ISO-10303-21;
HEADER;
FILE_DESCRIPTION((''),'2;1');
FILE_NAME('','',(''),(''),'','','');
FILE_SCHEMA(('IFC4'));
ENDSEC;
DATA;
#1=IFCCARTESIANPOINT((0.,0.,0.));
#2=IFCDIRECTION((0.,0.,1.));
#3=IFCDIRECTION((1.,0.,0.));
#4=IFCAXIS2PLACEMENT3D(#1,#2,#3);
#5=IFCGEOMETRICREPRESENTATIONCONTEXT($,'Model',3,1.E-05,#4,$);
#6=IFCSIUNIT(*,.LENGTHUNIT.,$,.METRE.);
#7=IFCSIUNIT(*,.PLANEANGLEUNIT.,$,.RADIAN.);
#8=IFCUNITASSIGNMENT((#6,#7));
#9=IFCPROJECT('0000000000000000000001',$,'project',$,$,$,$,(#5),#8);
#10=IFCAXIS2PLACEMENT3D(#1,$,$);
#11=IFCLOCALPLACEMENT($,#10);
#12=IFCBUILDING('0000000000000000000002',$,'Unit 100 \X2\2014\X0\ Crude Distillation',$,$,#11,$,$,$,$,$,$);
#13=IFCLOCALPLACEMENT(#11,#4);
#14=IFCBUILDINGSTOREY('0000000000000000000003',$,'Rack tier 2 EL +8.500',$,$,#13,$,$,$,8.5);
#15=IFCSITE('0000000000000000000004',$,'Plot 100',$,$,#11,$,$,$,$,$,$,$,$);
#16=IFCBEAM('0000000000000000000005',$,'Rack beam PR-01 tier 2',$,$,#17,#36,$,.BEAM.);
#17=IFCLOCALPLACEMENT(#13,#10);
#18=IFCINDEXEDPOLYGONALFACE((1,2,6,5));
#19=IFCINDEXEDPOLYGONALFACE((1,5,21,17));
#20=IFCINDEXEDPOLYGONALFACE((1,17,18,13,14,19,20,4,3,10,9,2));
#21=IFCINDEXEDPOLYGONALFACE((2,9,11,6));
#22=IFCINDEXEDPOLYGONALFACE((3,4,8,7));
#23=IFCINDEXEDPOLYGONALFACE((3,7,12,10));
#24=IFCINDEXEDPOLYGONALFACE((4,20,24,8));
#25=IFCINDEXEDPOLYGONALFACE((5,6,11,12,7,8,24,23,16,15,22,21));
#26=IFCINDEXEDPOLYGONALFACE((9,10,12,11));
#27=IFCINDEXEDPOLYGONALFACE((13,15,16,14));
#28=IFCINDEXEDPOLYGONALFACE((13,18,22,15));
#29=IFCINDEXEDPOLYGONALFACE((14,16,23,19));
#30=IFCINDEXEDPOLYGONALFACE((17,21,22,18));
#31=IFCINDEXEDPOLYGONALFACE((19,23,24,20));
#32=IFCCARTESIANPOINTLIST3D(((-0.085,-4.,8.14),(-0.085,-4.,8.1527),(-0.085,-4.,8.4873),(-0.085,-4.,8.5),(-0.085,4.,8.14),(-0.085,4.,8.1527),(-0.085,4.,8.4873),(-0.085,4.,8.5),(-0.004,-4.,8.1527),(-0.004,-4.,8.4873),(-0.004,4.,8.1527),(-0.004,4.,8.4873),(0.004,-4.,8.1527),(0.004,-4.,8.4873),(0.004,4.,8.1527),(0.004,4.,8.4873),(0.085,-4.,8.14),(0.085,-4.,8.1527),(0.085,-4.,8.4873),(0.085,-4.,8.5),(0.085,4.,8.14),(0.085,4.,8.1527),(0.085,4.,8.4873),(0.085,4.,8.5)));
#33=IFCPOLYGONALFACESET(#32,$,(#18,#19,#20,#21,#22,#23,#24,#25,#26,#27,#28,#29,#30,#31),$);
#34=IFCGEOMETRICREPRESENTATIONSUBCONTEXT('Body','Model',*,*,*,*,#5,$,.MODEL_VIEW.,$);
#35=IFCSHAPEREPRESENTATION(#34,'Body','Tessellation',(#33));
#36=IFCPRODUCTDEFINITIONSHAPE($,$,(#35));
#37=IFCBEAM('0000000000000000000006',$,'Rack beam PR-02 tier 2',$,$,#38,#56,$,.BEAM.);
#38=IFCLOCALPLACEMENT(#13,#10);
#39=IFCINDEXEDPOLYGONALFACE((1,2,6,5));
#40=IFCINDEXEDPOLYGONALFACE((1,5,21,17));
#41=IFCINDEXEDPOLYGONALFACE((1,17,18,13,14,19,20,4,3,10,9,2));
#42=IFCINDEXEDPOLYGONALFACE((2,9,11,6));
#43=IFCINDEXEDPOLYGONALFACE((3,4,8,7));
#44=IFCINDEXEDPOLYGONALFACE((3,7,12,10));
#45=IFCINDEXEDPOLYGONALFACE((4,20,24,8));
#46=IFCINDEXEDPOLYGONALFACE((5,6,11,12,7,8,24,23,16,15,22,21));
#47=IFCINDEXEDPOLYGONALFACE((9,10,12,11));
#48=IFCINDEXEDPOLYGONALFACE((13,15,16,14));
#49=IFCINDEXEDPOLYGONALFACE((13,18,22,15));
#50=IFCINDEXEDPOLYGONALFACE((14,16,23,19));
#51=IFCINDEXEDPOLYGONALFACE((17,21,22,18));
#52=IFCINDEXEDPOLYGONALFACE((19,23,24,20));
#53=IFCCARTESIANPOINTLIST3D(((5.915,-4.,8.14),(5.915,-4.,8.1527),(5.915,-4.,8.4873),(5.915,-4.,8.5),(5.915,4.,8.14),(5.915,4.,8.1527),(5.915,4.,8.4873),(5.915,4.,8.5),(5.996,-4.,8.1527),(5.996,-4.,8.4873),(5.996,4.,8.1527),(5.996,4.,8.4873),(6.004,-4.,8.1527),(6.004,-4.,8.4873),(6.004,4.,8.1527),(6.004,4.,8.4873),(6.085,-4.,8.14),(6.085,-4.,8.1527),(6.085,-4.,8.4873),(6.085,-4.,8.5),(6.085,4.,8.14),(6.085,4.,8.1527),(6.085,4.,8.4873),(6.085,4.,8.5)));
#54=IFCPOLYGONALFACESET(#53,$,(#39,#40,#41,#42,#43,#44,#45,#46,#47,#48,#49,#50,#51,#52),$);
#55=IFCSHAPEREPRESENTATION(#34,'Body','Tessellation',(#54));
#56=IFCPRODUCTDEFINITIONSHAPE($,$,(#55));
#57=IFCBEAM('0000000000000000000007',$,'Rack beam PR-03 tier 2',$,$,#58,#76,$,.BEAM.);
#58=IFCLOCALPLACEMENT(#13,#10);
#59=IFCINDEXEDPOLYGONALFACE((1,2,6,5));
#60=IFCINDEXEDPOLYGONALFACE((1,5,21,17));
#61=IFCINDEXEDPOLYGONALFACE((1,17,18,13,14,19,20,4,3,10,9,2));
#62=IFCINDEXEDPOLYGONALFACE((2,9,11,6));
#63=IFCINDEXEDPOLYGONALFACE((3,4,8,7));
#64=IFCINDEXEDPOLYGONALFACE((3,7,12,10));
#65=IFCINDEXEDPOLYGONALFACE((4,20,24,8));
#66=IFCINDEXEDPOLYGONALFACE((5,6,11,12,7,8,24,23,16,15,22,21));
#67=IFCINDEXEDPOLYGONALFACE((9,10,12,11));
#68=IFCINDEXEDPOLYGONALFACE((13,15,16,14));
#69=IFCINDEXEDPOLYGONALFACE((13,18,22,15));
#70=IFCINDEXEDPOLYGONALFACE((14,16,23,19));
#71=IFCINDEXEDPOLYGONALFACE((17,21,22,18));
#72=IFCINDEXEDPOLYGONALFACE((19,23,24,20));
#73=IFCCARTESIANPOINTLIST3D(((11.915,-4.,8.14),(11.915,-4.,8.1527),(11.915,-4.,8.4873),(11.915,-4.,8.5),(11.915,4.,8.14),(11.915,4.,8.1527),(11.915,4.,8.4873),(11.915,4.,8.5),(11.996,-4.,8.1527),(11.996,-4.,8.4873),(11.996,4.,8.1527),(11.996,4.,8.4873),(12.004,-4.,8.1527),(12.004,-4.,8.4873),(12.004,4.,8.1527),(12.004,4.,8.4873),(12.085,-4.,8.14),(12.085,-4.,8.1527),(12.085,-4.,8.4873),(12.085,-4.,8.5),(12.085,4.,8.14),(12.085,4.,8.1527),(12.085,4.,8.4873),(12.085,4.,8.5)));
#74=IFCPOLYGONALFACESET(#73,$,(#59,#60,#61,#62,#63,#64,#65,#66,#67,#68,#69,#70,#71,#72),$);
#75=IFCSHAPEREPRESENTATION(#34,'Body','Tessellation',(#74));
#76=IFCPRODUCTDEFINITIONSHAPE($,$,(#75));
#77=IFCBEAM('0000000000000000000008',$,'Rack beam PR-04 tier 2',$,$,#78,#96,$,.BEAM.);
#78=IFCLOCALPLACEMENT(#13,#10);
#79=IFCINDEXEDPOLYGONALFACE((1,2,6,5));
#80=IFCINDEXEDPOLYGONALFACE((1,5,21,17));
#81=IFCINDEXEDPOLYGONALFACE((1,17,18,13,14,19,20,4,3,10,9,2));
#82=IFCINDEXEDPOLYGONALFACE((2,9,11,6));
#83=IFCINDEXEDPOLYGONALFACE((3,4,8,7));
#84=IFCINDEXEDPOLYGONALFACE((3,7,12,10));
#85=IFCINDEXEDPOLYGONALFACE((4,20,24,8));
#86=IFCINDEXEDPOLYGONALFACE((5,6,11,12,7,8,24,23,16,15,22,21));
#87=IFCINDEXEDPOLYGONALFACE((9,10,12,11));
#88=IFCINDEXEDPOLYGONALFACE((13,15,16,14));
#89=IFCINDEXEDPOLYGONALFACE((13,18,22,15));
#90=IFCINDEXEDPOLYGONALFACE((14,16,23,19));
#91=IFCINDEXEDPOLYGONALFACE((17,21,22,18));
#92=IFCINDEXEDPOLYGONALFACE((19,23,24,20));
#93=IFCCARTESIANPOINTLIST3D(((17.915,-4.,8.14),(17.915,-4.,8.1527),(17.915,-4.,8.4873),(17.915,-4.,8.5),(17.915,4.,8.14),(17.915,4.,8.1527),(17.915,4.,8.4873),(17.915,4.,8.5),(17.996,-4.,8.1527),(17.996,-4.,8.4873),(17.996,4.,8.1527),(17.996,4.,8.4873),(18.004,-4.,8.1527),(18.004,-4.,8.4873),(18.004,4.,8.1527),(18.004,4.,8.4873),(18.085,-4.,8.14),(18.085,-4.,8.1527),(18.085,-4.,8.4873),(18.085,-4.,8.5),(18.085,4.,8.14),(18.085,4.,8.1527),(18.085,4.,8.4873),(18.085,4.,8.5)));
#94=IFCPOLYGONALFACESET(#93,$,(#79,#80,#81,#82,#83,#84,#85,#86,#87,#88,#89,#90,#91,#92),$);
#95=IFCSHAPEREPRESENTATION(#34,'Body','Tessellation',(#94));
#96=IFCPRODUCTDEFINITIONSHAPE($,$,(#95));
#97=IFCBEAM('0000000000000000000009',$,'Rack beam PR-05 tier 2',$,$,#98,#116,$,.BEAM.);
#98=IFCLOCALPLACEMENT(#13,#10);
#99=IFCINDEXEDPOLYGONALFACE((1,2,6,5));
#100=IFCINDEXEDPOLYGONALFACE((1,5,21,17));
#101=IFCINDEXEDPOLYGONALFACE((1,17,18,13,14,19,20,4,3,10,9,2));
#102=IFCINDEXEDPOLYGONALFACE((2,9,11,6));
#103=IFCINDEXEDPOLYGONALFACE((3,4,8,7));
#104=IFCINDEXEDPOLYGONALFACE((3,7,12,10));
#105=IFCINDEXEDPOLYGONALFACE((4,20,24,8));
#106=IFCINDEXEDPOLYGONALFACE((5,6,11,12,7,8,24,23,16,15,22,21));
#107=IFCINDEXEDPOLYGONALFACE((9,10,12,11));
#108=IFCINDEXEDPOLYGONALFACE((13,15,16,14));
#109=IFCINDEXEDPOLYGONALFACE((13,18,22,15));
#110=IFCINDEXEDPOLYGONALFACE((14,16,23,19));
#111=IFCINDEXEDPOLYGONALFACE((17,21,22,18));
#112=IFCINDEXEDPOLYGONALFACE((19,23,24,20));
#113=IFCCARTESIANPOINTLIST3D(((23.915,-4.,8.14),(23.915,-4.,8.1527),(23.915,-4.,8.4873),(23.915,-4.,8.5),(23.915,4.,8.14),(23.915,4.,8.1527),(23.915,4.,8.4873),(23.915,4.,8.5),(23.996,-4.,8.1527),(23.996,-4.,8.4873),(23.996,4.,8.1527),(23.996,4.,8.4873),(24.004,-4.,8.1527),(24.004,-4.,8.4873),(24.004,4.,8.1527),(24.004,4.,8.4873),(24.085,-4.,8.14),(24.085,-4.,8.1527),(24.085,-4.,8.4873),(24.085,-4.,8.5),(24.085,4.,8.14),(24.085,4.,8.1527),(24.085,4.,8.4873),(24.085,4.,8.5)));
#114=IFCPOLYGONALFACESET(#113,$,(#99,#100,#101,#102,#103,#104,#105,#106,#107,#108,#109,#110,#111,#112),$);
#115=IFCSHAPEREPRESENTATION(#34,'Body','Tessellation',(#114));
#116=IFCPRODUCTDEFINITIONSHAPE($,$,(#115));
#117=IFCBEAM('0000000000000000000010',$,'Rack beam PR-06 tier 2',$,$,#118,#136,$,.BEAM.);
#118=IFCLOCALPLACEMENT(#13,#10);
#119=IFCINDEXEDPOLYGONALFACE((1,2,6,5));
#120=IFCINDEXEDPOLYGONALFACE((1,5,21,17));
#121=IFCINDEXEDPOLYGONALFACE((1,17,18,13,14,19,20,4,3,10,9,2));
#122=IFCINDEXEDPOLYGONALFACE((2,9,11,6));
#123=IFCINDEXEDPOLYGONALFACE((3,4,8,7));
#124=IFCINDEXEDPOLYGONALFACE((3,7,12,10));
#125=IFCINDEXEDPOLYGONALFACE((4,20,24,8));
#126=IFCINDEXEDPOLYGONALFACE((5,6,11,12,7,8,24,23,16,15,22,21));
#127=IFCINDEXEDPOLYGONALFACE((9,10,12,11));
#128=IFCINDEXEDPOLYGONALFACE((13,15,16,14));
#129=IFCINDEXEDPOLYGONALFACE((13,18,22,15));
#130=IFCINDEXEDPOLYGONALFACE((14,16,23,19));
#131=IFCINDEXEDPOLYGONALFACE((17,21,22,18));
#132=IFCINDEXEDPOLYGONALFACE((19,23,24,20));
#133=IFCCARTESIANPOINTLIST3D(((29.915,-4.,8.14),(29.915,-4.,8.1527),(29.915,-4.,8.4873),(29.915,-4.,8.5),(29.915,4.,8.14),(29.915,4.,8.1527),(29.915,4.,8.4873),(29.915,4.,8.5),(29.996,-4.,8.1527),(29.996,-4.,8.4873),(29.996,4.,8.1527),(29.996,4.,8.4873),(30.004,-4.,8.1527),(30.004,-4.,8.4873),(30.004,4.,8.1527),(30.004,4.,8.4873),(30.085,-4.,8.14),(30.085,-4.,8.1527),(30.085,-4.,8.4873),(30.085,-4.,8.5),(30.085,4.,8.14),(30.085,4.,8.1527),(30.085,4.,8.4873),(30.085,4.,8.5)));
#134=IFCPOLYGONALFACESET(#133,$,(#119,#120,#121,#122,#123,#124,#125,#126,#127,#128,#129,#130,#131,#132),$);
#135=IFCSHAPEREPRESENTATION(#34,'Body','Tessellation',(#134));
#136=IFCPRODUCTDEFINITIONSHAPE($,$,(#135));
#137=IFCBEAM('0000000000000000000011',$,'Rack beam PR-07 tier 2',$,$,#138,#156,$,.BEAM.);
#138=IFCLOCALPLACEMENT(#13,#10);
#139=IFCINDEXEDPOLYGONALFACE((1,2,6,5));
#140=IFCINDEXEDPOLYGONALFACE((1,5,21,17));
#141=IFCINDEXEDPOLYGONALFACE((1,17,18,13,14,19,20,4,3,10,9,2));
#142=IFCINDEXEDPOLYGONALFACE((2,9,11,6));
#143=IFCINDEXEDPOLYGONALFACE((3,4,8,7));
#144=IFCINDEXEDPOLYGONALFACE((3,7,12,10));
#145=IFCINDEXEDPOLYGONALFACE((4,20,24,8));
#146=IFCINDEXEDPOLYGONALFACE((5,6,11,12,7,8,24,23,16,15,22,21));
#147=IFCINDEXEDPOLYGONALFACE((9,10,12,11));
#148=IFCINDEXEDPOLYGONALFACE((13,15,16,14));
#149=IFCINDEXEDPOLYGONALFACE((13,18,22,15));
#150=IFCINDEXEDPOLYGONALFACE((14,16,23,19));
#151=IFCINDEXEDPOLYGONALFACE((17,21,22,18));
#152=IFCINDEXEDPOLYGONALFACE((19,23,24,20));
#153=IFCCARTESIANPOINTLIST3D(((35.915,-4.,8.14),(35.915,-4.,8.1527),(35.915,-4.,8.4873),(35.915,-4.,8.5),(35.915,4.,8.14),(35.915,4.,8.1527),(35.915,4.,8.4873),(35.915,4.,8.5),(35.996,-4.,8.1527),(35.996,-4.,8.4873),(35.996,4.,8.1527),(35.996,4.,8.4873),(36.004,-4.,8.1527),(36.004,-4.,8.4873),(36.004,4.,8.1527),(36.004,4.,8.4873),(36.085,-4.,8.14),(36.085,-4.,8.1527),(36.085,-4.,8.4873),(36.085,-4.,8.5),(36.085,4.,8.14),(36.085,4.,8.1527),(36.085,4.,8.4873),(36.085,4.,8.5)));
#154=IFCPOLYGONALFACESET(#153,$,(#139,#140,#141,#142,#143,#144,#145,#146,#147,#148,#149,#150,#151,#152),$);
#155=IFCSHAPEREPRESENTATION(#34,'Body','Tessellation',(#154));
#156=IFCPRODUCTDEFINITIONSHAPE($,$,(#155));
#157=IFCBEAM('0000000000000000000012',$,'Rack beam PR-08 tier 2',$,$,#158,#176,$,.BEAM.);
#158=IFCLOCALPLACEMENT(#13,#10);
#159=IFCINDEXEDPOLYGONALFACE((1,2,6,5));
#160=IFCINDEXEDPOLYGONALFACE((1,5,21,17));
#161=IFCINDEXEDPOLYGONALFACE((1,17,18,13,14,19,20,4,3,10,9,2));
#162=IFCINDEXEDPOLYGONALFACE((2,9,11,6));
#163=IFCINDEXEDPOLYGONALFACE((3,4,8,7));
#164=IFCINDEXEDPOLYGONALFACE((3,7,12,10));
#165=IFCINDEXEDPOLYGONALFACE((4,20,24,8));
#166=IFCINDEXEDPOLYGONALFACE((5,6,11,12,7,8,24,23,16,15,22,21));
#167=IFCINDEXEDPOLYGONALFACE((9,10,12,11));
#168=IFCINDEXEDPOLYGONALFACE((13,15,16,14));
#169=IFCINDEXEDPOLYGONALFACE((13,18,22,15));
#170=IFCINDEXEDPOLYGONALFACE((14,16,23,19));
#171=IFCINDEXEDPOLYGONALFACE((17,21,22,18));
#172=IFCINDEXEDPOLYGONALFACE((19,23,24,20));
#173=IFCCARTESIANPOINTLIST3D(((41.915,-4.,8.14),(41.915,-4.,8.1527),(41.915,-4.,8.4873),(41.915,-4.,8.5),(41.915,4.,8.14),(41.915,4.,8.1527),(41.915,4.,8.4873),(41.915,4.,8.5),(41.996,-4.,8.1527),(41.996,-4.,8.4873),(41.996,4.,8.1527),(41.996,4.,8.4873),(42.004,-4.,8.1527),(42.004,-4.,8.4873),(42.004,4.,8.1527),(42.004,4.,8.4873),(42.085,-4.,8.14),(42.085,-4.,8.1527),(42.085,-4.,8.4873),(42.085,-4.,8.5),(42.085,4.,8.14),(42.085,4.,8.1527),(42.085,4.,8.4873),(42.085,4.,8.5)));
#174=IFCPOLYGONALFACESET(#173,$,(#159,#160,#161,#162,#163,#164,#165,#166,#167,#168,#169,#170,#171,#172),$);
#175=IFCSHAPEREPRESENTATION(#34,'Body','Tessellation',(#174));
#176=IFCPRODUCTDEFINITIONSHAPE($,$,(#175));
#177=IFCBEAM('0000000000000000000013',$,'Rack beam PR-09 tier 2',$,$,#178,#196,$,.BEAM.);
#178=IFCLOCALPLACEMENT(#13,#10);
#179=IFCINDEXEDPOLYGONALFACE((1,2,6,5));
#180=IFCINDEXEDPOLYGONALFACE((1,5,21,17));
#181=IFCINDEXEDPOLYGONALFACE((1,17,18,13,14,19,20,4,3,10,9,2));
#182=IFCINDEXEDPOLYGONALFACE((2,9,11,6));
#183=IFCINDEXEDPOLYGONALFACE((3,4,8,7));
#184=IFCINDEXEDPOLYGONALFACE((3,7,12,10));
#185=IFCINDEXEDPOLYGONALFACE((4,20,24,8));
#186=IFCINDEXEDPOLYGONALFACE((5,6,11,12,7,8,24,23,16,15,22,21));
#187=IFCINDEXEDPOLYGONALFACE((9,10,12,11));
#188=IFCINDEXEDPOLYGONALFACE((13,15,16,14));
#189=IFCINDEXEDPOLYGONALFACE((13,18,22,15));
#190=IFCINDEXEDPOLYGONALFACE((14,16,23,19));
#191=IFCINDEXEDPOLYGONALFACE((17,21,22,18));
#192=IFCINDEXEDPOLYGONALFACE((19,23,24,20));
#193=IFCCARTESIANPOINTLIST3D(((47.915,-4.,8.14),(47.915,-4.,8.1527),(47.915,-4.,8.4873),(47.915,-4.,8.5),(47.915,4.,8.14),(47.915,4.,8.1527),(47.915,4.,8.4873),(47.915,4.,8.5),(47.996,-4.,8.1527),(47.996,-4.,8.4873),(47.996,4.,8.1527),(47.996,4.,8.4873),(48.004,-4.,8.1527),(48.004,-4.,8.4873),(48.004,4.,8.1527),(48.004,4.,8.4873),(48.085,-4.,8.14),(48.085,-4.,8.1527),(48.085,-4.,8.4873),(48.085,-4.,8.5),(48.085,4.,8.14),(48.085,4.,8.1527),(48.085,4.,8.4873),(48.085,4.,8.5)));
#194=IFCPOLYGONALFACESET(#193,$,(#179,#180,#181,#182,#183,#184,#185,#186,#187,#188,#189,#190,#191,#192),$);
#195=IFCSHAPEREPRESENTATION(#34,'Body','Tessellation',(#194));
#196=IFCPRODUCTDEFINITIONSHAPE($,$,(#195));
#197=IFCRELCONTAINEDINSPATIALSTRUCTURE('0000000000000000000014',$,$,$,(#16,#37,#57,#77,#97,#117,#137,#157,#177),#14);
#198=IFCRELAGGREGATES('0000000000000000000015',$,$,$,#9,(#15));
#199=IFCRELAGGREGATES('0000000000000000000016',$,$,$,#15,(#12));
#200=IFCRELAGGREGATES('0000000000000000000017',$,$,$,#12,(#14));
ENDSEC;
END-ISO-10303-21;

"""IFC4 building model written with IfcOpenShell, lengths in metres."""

from ifc_helpers import new_model, si_unit, frame, origin, origin_with_axes, origin_2d, place, context, subcontext, project, spatial, i_section, extrude, element, save


model = new_model("IFC4")

# Units and contexts
model_context = context("Model", 3, precision=1e-05, world=origin_with_axes())
body_context = subcontext(model_context, "Body", "Model", "MODEL_VIEW")
ifc_project = project(units=[si_unit("LENGTHUNIT", "METRE"), si_unit("PLANEANGLEUNIT", "RADIAN")], contexts=[model_context])

# Site, building, storey
placement = place(None, origin())
site = spatial("IfcSite", under=ifc_project, at=placement, Name="Plot 100")
building = spatial("IfcBuilding", under=site, at=placement, Name="Unit 100 — Crude Distillation")
storey_placement = place(placement, origin_with_axes())
storey = spatial("IfcBuildingStorey", under=building, at=storey_placement, Name="Rack tier 2 EL +8.500", Elevation=8.5)

# Beams
beam_1_placement = place(storey_placement, origin_with_axes())
element("IfcBeam", 1, at=beam_1_placement, inside=storey, Name="Rack beam PR-01 tier 2", PredefinedType="BEAM", context=body_context, shape_type="SweptSolid", body=[
    extrude(i_section(OverallWidth=0.17, OverallDepth=0.36, WebThickness=0.008, FlangeThickness=0.0127, at=origin_2d()), frame((0.0, -4.0, 8.32), z_axis=(0.0, 1.0, 0.0), x_axis=(-1.0, 0.0, 0.0)), (0.0, 0.0, 1.0), 8.0),
])
beam_2_placement = place(storey_placement, origin_with_axes())
element("IfcBeam", 2, at=beam_2_placement, inside=storey, Name="Rack beam PR-02 tier 2", PredefinedType="BEAM", context=body_context, shape_type="SweptSolid", body=[
    extrude(i_section(OverallWidth=0.17, OverallDepth=0.36, WebThickness=0.008, FlangeThickness=0.0127, at=origin_2d()), frame((6.0, -4.0, 8.32), z_axis=(0.0, 1.0, 0.0), x_axis=(-1.0, 0.0, 0.0)), (0.0, 0.0, 1.0), 8.0),
])
beam_3_placement = place(storey_placement, origin_with_axes())
element("IfcBeam", 3, at=beam_3_placement, inside=storey, Name="Rack beam PR-03 tier 2", PredefinedType="BEAM", context=body_context, shape_type="SweptSolid", body=[
    extrude(i_section(OverallWidth=0.17, OverallDepth=0.36, WebThickness=0.008, FlangeThickness=0.0127, at=origin_2d()), frame((12.0, -4.0, 8.32), z_axis=(0.0, 1.0, 0.0), x_axis=(-1.0, 0.0, 0.0)), (0.0, 0.0, 1.0), 8.0),
])
beam_4_placement = place(storey_placement, origin_with_axes())
element("IfcBeam", 4, at=beam_4_placement, inside=storey, Name="Rack beam PR-04 tier 2", PredefinedType="BEAM", context=body_context, shape_type="SweptSolid", body=[
    extrude(i_section(OverallWidth=0.17, OverallDepth=0.36, WebThickness=0.008, FlangeThickness=0.0127, at=origin_2d()), frame((18.0, -4.0, 8.32), z_axis=(0.0, 1.0, 0.0), x_axis=(-1.0, 0.0, 0.0)), (0.0, 0.0, 1.0), 8.0),
])
beam_5_placement = place(storey_placement, origin_with_axes())
element("IfcBeam", 5, at=beam_5_placement, inside=storey, Name="Rack beam PR-05 tier 2", PredefinedType="BEAM", context=body_context, shape_type="SweptSolid", body=[
    extrude(i_section(OverallWidth=0.17, OverallDepth=0.36, WebThickness=0.008, FlangeThickness=0.0127, at=origin_2d()), frame((24.0, -4.0, 8.32), z_axis=(0.0, 1.0, 0.0), x_axis=(-1.0, 0.0, 0.0)), (0.0, 0.0, 1.0), 8.0),
])
beam_6_placement = place(storey_placement, origin_with_axes())
element("IfcBeam", 6, at=beam_6_placement, inside=storey, Name="Rack beam PR-06 tier 2", PredefinedType="BEAM", context=body_context, shape_type="SweptSolid", body=[
    extrude(i_section(OverallWidth=0.17, OverallDepth=0.36, WebThickness=0.008, FlangeThickness=0.0127, at=origin_2d()), frame((30.0, -4.0, 8.32), z_axis=(0.0, 1.0, 0.0), x_axis=(-1.0, 0.0, 0.0)), (0.0, 0.0, 1.0), 8.0),
])
beam_7_placement = place(storey_placement, origin_with_axes())
element("IfcBeam", 7, at=beam_7_placement, inside=storey, Name="Rack beam PR-07 tier 2", PredefinedType="BEAM", context=body_context, shape_type="SweptSolid", body=[
    extrude(i_section(OverallWidth=0.17, OverallDepth=0.36, WebThickness=0.008, FlangeThickness=0.0127, at=origin_2d()), frame((36.0, -4.0, 8.32), z_axis=(0.0, 1.0, 0.0), x_axis=(-1.0, 0.0, 0.0)), (0.0, 0.0, 1.0), 8.0),
])
beam_8_placement = place(storey_placement, origin_with_axes())
element("IfcBeam", 8, at=beam_8_placement, inside=storey, Name="Rack beam PR-08 tier 2", PredefinedType="BEAM", context=body_context, shape_type="SweptSolid", body=[
    extrude(i_section(OverallWidth=0.17, OverallDepth=0.36, WebThickness=0.008, FlangeThickness=0.0127, at=origin_2d()), frame((42.0, -4.0, 8.32), z_axis=(0.0, 1.0, 0.0), x_axis=(-1.0, 0.0, 0.0)), (0.0, 0.0, 1.0), 8.0),
])
beam_9_placement = place(storey_placement, origin_with_axes())
element("IfcBeam", 9, at=beam_9_placement, inside=storey, Name="Rack beam PR-09 tier 2", PredefinedType="BEAM", context=body_context, shape_type="SweptSolid", body=[
    extrude(i_section(OverallWidth=0.17, OverallDepth=0.36, WebThickness=0.008, FlangeThickness=0.0127, at=origin_2d()), frame((48.0, -4.0, 8.32), z_axis=(0.0, 1.0, 0.0), x_axis=(-1.0, 0.0, 0.0)), (0.0, 0.0, 1.0), 8.0),
])

save(model, "model.ifc")
